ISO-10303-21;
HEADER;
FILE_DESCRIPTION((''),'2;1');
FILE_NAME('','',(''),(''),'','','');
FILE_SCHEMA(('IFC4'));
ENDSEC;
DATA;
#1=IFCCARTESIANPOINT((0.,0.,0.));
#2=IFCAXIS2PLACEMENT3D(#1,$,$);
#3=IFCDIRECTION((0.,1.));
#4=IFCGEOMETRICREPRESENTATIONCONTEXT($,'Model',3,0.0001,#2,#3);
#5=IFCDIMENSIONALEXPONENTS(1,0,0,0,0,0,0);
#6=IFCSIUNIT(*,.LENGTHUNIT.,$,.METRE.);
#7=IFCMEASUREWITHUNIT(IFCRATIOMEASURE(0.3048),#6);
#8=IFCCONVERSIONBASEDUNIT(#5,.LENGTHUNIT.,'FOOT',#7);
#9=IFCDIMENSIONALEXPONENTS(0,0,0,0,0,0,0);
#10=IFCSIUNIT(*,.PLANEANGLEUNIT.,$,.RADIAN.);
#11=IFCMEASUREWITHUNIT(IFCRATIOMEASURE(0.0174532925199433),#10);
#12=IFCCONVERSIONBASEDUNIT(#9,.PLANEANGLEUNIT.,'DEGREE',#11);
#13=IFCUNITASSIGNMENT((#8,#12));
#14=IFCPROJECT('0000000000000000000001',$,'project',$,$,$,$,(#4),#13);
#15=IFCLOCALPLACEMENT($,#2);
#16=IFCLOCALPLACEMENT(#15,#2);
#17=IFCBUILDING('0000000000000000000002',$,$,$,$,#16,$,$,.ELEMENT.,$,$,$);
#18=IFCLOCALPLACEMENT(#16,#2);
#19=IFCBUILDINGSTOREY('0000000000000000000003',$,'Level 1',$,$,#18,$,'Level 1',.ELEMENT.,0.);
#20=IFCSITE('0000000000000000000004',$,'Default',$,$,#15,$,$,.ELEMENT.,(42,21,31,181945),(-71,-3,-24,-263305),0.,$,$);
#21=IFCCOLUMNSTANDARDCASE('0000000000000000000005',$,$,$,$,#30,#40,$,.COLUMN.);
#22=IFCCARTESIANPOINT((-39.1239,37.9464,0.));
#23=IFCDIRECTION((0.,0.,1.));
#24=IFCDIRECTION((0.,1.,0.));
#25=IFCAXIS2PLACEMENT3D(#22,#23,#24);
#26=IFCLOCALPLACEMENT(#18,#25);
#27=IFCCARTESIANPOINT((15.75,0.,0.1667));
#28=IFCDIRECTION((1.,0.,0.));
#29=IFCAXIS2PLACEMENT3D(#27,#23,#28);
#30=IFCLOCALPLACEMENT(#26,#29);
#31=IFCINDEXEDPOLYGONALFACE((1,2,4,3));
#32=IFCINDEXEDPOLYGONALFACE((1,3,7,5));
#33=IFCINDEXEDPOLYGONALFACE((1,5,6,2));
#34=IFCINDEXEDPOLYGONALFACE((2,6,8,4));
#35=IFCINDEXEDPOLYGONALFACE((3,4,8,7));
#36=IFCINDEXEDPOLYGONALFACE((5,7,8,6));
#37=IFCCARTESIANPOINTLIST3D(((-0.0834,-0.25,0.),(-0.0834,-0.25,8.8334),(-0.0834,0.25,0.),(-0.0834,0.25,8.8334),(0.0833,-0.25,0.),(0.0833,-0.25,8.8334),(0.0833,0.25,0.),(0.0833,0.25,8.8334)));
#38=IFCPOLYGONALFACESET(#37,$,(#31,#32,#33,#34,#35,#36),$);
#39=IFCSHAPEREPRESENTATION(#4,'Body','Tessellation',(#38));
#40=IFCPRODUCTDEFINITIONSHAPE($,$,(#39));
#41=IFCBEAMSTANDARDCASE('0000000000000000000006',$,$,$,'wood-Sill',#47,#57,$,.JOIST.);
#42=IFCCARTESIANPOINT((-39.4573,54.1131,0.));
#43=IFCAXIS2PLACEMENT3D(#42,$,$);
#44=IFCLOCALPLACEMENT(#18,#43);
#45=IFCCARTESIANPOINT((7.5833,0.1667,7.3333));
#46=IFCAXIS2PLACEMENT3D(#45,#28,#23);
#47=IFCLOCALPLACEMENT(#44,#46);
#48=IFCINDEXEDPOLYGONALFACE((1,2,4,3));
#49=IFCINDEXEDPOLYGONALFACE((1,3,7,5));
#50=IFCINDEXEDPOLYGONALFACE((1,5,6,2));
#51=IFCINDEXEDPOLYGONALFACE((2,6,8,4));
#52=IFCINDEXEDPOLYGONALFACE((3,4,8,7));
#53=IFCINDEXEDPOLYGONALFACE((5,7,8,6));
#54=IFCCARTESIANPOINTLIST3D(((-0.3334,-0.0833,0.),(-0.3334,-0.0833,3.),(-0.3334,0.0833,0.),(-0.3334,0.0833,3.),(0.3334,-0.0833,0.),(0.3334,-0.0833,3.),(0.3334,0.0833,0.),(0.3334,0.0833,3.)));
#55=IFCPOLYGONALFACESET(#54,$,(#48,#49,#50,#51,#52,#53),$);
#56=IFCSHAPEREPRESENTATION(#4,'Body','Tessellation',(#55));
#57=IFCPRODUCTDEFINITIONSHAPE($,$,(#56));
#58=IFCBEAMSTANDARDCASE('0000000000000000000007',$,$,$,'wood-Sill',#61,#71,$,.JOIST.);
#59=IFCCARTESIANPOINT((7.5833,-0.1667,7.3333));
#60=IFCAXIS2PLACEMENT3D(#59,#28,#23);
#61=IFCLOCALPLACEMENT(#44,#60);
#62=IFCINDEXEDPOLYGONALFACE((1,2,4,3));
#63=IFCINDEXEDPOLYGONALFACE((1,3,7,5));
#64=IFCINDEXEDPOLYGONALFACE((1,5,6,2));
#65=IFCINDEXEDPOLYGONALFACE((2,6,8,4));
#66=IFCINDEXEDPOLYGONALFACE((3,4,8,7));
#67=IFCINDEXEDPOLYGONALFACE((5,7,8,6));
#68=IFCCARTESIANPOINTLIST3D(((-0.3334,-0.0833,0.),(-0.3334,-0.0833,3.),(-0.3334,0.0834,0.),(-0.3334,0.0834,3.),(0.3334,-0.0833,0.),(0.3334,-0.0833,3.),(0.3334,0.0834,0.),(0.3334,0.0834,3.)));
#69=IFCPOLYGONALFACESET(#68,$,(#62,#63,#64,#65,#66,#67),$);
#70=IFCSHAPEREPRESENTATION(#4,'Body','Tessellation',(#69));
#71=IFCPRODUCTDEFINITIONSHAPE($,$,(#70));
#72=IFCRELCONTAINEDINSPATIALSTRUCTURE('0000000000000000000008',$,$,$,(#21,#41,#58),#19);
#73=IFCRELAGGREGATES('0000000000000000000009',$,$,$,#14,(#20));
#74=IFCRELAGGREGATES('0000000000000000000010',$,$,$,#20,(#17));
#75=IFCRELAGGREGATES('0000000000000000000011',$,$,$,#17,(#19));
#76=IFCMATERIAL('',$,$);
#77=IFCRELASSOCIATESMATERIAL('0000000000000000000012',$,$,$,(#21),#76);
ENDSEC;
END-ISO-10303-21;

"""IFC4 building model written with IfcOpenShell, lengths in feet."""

from ifc_helpers import new_model, entity, si_unit, converted_unit, direction, frame, origin, origin_with_axes, place, context, project, spatial, rectangle, extrude, material, element, save


model = new_model("IFC4")

# Units and contexts
model_context = context("Model", 3, precision=0.0001, world=origin(), true_north=direction((0.0, 1.0)))
ifc_project = project(units=[converted_unit("LENGTHUNIT", "FOOT", entity("IfcRatioMeasure", 0.3048), si_unit("LENGTHUNIT", "METRE"), dimensions=[1, 0, 0, 0, 0, 0, 0]), converted_unit("PLANEANGLEUNIT", "DEGREE", entity("IfcRatioMeasure", 0.0174532925199433), si_unit("PLANEANGLEUNIT", "RADIAN"), dimensions=[0, 0, 0, 0, 0, 0, 0])], contexts=[model_context])

# Site, building, storey
site_placement = place(None, origin())
site = spatial("IfcSite", under=ifc_project, at=site_placement, Name="Default", CompositionType="ELEMENT", RefLatitude=(42, 21, 31, 181945), RefLongitude=(-71, -3, -24, -263305), RefElevation=0.0)
building_placement = place(site_placement, origin())
building = spatial("IfcBuilding", under=site, at=building_placement, CompositionType="ELEMENT")
storey_placement = place(building_placement, origin())
storey = spatial("IfcBuildingStorey", under=building, at=storey_placement, Name="Level 1", LongName="Level 1", CompositionType="ELEMENT", Elevation=0.0)

# Column
placement_1 = place(storey_placement, frame((-39.4573, 54.1131, 0.0)))
ifc_material_1 = material(Name="")
placement_2 = place(storey_placement, frame((-39.1239, 37.9464, 0.0), z_axis=(0.0, 0.0, 1.0), x_axis=(0.0, 1.0, 0.0)))
for number, where, z_axis, x_axis in (
    (1, (15.75, 0.0, 0.1667), (0.0, 0.0, 1.0), (1.0, 0.0, 0.0)),
):
    element("IfcColumnStandardCase", number, at=place(placement_2, frame(where, z_axis=z_axis, x_axis=x_axis)), inside=storey, material=ifc_material_1, PredefinedType="COLUMN", context=model_context, shape_type="SweptSolid", body=[
        extrude(rectangle(XDim=0.1667, YDim=0.5), origin(), (0.0, 0.0, 1.0), 8.8334),
    ])

# Beams
for number, where, z_axis, x_axis in (
    (2, (7.5833, 0.1667, 7.3333), (1.0, 0.0, 0.0), (0.0, 0.0, 1.0)),
    (3, (7.5833, -0.1667, 7.3333), (1.0, 0.0, 0.0), (0.0, 0.0, 1.0)),
):
    element("IfcBeamStandardCase", number, at=place(placement_1, frame(where, z_axis=z_axis, x_axis=x_axis)), inside=storey, ObjectType="wood-Sill", PredefinedType="JOIST", context=model_context, shape_type="SweptSolid", body=[
        extrude(rectangle(XDim=0.6667, YDim=0.1667), origin_with_axes(), (0.0, 0.0, 1.0), 3.0),
    ])

save(model, "model.ifc")
